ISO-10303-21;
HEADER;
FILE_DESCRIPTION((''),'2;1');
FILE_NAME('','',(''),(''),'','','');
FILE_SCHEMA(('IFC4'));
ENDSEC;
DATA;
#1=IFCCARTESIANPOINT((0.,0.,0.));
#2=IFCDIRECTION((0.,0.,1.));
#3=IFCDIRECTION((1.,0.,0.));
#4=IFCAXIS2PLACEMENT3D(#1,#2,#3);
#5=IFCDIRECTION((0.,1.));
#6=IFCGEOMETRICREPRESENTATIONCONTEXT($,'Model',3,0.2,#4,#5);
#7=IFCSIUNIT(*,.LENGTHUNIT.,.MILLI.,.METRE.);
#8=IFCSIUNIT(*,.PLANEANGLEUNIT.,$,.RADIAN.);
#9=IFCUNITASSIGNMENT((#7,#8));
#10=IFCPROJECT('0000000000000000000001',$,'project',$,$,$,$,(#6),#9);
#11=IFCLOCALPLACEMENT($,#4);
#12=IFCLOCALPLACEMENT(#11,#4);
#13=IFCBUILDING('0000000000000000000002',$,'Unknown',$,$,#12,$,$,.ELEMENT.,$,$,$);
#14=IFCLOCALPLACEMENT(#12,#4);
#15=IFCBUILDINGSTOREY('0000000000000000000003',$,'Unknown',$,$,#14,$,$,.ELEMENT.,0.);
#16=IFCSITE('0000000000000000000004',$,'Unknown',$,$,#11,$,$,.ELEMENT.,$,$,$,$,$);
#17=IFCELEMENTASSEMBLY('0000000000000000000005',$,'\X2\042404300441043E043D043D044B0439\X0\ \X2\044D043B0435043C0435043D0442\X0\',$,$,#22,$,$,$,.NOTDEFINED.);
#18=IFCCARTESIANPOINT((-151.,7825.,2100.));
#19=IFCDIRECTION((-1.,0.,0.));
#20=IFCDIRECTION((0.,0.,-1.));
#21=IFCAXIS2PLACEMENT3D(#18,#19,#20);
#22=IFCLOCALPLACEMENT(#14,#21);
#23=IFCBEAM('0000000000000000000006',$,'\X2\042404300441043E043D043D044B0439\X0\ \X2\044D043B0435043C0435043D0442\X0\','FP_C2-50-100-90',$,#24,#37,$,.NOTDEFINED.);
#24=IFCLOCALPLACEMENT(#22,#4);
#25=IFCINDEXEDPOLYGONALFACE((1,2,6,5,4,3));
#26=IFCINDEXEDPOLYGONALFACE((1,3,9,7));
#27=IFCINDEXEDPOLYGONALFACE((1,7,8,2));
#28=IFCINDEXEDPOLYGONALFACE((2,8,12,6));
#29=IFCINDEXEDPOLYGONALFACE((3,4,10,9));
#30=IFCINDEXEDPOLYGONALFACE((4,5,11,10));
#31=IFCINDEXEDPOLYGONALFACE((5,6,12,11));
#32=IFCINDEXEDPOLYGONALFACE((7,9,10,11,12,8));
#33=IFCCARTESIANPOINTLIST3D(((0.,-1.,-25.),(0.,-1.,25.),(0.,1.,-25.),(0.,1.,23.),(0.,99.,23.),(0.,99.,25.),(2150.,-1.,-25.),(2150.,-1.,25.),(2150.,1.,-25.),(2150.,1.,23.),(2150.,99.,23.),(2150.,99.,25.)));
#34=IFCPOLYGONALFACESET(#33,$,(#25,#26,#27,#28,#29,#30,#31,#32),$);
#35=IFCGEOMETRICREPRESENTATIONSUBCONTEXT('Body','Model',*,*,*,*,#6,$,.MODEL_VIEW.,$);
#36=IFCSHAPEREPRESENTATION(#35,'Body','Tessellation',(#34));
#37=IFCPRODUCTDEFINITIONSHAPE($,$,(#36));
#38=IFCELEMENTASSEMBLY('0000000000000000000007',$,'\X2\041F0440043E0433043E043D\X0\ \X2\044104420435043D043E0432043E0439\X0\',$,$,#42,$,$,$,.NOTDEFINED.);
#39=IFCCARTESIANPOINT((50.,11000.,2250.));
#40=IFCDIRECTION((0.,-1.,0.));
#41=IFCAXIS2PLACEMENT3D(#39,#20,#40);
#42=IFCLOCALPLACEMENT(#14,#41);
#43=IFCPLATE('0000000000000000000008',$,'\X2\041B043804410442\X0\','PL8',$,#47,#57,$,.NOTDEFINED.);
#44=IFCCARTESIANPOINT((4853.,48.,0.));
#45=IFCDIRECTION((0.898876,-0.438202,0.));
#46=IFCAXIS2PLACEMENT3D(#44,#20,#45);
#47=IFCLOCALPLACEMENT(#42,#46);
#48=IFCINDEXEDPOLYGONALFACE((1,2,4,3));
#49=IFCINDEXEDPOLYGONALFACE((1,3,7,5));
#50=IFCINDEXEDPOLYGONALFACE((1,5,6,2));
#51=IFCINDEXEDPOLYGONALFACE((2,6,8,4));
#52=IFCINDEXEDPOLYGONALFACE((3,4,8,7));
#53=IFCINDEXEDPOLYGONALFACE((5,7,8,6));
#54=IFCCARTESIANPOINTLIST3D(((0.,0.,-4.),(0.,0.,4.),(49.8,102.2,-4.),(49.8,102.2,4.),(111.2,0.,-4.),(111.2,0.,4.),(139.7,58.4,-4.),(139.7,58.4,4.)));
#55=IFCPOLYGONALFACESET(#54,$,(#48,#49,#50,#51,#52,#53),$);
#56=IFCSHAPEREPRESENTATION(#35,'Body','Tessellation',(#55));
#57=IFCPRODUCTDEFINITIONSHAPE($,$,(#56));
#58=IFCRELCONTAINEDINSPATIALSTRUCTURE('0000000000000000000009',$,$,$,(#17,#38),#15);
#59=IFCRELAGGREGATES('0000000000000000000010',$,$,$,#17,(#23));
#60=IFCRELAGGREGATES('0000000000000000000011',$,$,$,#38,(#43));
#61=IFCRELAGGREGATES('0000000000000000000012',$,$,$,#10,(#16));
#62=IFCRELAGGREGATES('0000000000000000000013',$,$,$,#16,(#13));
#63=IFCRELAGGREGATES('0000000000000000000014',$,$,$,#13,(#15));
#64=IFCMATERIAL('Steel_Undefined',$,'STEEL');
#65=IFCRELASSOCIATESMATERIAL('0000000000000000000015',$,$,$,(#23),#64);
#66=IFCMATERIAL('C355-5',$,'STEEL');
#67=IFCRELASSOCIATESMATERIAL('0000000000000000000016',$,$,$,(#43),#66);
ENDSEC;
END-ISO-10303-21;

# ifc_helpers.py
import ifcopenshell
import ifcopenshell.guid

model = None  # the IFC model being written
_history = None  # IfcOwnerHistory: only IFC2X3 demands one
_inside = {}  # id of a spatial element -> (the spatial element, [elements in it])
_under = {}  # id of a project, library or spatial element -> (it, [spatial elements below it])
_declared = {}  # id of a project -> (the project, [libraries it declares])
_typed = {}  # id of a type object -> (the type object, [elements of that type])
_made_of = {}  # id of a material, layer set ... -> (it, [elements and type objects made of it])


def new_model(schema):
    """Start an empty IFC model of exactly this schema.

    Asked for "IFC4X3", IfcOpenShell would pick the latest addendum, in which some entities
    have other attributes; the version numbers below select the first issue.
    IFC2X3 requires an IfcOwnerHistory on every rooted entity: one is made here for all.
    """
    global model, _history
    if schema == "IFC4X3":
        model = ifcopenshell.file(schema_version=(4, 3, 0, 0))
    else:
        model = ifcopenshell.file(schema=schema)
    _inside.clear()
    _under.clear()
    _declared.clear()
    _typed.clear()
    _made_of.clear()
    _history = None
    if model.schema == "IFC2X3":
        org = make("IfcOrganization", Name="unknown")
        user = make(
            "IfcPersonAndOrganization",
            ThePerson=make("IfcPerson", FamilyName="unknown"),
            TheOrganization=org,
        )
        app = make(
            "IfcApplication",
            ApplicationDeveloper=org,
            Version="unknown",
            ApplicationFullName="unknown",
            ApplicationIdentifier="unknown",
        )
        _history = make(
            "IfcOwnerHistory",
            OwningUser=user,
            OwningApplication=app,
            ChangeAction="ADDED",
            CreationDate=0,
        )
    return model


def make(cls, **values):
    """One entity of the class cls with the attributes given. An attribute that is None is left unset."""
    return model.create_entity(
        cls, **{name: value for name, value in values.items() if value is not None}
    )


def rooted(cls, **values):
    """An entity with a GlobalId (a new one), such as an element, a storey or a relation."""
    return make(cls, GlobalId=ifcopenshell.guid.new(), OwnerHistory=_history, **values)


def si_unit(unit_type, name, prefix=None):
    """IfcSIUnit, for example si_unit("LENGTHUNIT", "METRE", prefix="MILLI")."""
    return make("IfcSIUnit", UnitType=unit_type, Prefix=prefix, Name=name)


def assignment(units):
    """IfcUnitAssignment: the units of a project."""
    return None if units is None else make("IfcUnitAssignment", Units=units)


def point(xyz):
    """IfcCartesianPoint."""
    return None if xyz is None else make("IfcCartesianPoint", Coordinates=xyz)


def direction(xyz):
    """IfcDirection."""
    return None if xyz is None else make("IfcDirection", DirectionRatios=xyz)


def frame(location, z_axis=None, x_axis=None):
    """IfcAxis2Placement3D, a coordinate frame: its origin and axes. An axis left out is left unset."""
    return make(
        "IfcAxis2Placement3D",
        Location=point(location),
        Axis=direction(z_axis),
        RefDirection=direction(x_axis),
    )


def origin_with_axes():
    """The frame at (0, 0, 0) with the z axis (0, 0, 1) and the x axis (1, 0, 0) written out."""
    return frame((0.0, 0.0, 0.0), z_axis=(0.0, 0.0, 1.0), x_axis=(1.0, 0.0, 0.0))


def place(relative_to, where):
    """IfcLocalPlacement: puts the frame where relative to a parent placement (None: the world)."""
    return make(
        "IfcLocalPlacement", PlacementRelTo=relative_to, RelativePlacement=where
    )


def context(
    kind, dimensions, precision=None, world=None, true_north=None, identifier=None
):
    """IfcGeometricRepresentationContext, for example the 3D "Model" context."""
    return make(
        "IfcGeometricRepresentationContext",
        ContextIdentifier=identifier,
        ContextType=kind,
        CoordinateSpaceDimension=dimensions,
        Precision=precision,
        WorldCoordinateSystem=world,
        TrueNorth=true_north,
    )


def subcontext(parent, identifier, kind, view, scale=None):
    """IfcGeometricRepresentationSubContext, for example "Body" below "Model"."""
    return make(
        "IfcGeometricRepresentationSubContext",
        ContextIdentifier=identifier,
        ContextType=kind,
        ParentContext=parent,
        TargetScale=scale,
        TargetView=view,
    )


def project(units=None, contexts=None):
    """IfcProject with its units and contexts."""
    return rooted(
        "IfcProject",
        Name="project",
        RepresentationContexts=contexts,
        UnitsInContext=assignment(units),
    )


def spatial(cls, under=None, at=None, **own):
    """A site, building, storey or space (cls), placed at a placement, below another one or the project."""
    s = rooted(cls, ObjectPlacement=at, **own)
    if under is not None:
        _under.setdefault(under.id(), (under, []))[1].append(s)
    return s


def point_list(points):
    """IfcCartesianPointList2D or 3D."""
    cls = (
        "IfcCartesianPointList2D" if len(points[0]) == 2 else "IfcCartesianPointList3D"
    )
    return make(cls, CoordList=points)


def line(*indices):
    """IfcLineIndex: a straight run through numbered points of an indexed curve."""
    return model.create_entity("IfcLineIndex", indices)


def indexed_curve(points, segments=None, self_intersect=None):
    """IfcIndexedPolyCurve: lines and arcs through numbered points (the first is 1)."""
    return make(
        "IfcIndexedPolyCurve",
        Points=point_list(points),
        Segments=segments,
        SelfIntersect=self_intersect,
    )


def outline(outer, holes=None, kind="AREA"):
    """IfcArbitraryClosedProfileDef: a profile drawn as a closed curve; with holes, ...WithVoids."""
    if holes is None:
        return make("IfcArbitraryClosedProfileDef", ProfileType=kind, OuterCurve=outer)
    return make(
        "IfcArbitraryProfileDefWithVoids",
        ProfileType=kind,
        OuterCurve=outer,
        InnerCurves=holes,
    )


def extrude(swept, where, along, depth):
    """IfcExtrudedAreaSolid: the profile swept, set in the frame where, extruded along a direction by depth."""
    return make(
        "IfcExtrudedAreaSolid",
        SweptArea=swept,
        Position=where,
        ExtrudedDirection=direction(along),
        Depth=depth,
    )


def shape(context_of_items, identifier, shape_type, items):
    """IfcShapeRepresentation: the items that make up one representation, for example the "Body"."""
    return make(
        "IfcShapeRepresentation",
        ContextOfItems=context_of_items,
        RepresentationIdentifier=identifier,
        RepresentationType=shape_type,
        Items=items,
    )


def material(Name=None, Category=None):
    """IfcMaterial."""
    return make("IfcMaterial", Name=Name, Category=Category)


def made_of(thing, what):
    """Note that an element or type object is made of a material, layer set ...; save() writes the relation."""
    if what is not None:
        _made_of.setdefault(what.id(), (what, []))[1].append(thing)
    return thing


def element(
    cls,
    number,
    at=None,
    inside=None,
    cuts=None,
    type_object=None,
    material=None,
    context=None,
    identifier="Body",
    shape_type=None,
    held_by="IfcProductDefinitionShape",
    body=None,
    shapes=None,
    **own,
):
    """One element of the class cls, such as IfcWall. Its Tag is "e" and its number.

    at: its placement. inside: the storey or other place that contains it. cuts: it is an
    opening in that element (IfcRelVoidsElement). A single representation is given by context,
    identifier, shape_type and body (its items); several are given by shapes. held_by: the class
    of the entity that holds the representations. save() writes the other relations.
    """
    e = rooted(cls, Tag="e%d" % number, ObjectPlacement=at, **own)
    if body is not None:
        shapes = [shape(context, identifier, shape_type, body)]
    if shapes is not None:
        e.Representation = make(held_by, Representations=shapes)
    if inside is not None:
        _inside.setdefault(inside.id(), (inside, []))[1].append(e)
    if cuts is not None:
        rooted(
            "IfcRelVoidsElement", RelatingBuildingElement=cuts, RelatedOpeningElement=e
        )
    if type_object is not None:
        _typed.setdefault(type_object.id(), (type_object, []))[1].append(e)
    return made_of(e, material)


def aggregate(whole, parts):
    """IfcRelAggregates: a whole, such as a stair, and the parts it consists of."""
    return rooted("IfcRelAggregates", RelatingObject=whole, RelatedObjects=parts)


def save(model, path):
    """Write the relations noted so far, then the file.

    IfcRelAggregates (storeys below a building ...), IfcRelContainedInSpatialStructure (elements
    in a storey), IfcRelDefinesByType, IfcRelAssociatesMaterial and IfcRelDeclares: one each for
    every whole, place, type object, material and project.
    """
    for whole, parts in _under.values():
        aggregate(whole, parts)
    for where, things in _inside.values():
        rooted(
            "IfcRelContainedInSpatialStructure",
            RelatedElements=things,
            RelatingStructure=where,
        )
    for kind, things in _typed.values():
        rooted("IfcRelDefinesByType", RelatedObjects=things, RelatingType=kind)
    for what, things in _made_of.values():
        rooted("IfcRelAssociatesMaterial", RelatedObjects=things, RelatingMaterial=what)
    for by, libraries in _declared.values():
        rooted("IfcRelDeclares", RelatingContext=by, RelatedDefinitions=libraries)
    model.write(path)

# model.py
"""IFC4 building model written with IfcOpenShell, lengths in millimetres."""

from ifc_helpers import new_model, si_unit, direction, frame, origin_with_axes, place, context, subcontext, project, spatial, line, indexed_curve, outline, extrude, material, element, aggregate, save


model = new_model("IFC4")

# Units and contexts
model_context = context("Model", 3, precision=0.2, world=origin_with_axes(), true_north=direction((0.0, 1.0)))
body_context = subcontext(model_context, "Body", "Model", "MODEL_VIEW")
ifc_project = project(units=[si_unit("LENGTHUNIT", "METRE", prefix="MILLI"), si_unit("PLANEANGLEUNIT", "RADIAN")], contexts=[model_context])

# Site, building, storey
site_placement = place(None, origin_with_axes())
site = spatial("IfcSite", under=ifc_project, at=site_placement, Name="Unknown", CompositionType="ELEMENT")
building_placement = place(site_placement, origin_with_axes())
building = spatial("IfcBuilding", under=site, at=building_placement, Name="Unknown", CompositionType="ELEMENT")
storey_placement = place(building_placement, origin_with_axes())
storey = spatial("IfcBuildingStorey", under=building, at=storey_placement, Name="Unknown", CompositionType="ELEMENT", Elevation=0.0)

# Element assembly, beam
ifc_material_1 = material(Name="Steel_Undefined", Category="STEEL")
assembly_1_placement = place(storey_placement, frame((-151.0, 7825.0, 2100.0), z_axis=(-1.0, 0.0, 0.0), x_axis=(0.0, 0.0, -1.0)))
assembly_1 = element("IfcElementAssembly", 1, at=assembly_1_placement, inside=storey, Name="Фасонный элемент", PredefinedType="NOTDEFINED")
beam_1_placement = place(assembly_1_placement, origin_with_axes())
beam_1 = element("IfcBeam", 2, at=beam_1_placement, material=ifc_material_1, Name="Фасонный элемент", Description="FP_C2-50-100-90", PredefinedType="NOTDEFINED", context=body_context, shape_type="SolidModel", body=[
    extrude(outline(indexed_curve([(-25.0, -1.0), (25.0, -1.0), (25.0, 99.0), (23.0, 99.0), (23.0, 1.0), (-25.0, 1.0)], segments=[line(1, 2, 3, 4, 5, 6, 1)])), frame((0.0, 0.0, 0.0), z_axis=(-1.0, 0.0, 0.0), x_axis=(0.0, 0.0, 1.0)), (0.0, 0.0, -1.0), 2150.0),
])
aggregate(assembly_1, [beam_1])

# Shared definitions
ifc_material_2 = material(Name="C355-5", Category="STEEL")

# Element assembly, plate
assembly_2_placement = place(storey_placement, frame((50.0, 11000.0, 2250.0), z_axis=(0.0, 0.0, -1.0), x_axis=(0.0, -1.0, 0.0)))
assembly_2 = element("IfcElementAssembly", 3, at=assembly_2_placement, inside=storey, Name="Прогон стеновой", PredefinedType="NOTDEFINED")
plate_1_placement = place(assembly_2_placement, frame((4853.0, 48.0, 0.0), z_axis=(0.0, 0.0, -1.0), x_axis=(0.898876, -0.438202, 0.0)))
plate_1 = element("IfcPlate", 4, at=plate_1_placement, material=ifc_material_2, Name="Лист", Description="PL8", PredefinedType="NOTDEFINED", context=body_context, shape_type="SolidModel", body=[
    extrude(outline(indexed_curve([(0.0, 0.0), (111.2, 0.0), (139.7, 58.4), (49.8, 102.2)], segments=[line(1, 2, 3, 4, 1)])), frame((0.0, 0.0, 4.0), z_axis=(0.0, 0.0, 1.0), x_axis=(1.0, 0.0, 0.0)), (0.0, 0.0, -1.0), 8.0),
])
aggregate(assembly_2, [plate_1])

save(model, "model.ifc")
